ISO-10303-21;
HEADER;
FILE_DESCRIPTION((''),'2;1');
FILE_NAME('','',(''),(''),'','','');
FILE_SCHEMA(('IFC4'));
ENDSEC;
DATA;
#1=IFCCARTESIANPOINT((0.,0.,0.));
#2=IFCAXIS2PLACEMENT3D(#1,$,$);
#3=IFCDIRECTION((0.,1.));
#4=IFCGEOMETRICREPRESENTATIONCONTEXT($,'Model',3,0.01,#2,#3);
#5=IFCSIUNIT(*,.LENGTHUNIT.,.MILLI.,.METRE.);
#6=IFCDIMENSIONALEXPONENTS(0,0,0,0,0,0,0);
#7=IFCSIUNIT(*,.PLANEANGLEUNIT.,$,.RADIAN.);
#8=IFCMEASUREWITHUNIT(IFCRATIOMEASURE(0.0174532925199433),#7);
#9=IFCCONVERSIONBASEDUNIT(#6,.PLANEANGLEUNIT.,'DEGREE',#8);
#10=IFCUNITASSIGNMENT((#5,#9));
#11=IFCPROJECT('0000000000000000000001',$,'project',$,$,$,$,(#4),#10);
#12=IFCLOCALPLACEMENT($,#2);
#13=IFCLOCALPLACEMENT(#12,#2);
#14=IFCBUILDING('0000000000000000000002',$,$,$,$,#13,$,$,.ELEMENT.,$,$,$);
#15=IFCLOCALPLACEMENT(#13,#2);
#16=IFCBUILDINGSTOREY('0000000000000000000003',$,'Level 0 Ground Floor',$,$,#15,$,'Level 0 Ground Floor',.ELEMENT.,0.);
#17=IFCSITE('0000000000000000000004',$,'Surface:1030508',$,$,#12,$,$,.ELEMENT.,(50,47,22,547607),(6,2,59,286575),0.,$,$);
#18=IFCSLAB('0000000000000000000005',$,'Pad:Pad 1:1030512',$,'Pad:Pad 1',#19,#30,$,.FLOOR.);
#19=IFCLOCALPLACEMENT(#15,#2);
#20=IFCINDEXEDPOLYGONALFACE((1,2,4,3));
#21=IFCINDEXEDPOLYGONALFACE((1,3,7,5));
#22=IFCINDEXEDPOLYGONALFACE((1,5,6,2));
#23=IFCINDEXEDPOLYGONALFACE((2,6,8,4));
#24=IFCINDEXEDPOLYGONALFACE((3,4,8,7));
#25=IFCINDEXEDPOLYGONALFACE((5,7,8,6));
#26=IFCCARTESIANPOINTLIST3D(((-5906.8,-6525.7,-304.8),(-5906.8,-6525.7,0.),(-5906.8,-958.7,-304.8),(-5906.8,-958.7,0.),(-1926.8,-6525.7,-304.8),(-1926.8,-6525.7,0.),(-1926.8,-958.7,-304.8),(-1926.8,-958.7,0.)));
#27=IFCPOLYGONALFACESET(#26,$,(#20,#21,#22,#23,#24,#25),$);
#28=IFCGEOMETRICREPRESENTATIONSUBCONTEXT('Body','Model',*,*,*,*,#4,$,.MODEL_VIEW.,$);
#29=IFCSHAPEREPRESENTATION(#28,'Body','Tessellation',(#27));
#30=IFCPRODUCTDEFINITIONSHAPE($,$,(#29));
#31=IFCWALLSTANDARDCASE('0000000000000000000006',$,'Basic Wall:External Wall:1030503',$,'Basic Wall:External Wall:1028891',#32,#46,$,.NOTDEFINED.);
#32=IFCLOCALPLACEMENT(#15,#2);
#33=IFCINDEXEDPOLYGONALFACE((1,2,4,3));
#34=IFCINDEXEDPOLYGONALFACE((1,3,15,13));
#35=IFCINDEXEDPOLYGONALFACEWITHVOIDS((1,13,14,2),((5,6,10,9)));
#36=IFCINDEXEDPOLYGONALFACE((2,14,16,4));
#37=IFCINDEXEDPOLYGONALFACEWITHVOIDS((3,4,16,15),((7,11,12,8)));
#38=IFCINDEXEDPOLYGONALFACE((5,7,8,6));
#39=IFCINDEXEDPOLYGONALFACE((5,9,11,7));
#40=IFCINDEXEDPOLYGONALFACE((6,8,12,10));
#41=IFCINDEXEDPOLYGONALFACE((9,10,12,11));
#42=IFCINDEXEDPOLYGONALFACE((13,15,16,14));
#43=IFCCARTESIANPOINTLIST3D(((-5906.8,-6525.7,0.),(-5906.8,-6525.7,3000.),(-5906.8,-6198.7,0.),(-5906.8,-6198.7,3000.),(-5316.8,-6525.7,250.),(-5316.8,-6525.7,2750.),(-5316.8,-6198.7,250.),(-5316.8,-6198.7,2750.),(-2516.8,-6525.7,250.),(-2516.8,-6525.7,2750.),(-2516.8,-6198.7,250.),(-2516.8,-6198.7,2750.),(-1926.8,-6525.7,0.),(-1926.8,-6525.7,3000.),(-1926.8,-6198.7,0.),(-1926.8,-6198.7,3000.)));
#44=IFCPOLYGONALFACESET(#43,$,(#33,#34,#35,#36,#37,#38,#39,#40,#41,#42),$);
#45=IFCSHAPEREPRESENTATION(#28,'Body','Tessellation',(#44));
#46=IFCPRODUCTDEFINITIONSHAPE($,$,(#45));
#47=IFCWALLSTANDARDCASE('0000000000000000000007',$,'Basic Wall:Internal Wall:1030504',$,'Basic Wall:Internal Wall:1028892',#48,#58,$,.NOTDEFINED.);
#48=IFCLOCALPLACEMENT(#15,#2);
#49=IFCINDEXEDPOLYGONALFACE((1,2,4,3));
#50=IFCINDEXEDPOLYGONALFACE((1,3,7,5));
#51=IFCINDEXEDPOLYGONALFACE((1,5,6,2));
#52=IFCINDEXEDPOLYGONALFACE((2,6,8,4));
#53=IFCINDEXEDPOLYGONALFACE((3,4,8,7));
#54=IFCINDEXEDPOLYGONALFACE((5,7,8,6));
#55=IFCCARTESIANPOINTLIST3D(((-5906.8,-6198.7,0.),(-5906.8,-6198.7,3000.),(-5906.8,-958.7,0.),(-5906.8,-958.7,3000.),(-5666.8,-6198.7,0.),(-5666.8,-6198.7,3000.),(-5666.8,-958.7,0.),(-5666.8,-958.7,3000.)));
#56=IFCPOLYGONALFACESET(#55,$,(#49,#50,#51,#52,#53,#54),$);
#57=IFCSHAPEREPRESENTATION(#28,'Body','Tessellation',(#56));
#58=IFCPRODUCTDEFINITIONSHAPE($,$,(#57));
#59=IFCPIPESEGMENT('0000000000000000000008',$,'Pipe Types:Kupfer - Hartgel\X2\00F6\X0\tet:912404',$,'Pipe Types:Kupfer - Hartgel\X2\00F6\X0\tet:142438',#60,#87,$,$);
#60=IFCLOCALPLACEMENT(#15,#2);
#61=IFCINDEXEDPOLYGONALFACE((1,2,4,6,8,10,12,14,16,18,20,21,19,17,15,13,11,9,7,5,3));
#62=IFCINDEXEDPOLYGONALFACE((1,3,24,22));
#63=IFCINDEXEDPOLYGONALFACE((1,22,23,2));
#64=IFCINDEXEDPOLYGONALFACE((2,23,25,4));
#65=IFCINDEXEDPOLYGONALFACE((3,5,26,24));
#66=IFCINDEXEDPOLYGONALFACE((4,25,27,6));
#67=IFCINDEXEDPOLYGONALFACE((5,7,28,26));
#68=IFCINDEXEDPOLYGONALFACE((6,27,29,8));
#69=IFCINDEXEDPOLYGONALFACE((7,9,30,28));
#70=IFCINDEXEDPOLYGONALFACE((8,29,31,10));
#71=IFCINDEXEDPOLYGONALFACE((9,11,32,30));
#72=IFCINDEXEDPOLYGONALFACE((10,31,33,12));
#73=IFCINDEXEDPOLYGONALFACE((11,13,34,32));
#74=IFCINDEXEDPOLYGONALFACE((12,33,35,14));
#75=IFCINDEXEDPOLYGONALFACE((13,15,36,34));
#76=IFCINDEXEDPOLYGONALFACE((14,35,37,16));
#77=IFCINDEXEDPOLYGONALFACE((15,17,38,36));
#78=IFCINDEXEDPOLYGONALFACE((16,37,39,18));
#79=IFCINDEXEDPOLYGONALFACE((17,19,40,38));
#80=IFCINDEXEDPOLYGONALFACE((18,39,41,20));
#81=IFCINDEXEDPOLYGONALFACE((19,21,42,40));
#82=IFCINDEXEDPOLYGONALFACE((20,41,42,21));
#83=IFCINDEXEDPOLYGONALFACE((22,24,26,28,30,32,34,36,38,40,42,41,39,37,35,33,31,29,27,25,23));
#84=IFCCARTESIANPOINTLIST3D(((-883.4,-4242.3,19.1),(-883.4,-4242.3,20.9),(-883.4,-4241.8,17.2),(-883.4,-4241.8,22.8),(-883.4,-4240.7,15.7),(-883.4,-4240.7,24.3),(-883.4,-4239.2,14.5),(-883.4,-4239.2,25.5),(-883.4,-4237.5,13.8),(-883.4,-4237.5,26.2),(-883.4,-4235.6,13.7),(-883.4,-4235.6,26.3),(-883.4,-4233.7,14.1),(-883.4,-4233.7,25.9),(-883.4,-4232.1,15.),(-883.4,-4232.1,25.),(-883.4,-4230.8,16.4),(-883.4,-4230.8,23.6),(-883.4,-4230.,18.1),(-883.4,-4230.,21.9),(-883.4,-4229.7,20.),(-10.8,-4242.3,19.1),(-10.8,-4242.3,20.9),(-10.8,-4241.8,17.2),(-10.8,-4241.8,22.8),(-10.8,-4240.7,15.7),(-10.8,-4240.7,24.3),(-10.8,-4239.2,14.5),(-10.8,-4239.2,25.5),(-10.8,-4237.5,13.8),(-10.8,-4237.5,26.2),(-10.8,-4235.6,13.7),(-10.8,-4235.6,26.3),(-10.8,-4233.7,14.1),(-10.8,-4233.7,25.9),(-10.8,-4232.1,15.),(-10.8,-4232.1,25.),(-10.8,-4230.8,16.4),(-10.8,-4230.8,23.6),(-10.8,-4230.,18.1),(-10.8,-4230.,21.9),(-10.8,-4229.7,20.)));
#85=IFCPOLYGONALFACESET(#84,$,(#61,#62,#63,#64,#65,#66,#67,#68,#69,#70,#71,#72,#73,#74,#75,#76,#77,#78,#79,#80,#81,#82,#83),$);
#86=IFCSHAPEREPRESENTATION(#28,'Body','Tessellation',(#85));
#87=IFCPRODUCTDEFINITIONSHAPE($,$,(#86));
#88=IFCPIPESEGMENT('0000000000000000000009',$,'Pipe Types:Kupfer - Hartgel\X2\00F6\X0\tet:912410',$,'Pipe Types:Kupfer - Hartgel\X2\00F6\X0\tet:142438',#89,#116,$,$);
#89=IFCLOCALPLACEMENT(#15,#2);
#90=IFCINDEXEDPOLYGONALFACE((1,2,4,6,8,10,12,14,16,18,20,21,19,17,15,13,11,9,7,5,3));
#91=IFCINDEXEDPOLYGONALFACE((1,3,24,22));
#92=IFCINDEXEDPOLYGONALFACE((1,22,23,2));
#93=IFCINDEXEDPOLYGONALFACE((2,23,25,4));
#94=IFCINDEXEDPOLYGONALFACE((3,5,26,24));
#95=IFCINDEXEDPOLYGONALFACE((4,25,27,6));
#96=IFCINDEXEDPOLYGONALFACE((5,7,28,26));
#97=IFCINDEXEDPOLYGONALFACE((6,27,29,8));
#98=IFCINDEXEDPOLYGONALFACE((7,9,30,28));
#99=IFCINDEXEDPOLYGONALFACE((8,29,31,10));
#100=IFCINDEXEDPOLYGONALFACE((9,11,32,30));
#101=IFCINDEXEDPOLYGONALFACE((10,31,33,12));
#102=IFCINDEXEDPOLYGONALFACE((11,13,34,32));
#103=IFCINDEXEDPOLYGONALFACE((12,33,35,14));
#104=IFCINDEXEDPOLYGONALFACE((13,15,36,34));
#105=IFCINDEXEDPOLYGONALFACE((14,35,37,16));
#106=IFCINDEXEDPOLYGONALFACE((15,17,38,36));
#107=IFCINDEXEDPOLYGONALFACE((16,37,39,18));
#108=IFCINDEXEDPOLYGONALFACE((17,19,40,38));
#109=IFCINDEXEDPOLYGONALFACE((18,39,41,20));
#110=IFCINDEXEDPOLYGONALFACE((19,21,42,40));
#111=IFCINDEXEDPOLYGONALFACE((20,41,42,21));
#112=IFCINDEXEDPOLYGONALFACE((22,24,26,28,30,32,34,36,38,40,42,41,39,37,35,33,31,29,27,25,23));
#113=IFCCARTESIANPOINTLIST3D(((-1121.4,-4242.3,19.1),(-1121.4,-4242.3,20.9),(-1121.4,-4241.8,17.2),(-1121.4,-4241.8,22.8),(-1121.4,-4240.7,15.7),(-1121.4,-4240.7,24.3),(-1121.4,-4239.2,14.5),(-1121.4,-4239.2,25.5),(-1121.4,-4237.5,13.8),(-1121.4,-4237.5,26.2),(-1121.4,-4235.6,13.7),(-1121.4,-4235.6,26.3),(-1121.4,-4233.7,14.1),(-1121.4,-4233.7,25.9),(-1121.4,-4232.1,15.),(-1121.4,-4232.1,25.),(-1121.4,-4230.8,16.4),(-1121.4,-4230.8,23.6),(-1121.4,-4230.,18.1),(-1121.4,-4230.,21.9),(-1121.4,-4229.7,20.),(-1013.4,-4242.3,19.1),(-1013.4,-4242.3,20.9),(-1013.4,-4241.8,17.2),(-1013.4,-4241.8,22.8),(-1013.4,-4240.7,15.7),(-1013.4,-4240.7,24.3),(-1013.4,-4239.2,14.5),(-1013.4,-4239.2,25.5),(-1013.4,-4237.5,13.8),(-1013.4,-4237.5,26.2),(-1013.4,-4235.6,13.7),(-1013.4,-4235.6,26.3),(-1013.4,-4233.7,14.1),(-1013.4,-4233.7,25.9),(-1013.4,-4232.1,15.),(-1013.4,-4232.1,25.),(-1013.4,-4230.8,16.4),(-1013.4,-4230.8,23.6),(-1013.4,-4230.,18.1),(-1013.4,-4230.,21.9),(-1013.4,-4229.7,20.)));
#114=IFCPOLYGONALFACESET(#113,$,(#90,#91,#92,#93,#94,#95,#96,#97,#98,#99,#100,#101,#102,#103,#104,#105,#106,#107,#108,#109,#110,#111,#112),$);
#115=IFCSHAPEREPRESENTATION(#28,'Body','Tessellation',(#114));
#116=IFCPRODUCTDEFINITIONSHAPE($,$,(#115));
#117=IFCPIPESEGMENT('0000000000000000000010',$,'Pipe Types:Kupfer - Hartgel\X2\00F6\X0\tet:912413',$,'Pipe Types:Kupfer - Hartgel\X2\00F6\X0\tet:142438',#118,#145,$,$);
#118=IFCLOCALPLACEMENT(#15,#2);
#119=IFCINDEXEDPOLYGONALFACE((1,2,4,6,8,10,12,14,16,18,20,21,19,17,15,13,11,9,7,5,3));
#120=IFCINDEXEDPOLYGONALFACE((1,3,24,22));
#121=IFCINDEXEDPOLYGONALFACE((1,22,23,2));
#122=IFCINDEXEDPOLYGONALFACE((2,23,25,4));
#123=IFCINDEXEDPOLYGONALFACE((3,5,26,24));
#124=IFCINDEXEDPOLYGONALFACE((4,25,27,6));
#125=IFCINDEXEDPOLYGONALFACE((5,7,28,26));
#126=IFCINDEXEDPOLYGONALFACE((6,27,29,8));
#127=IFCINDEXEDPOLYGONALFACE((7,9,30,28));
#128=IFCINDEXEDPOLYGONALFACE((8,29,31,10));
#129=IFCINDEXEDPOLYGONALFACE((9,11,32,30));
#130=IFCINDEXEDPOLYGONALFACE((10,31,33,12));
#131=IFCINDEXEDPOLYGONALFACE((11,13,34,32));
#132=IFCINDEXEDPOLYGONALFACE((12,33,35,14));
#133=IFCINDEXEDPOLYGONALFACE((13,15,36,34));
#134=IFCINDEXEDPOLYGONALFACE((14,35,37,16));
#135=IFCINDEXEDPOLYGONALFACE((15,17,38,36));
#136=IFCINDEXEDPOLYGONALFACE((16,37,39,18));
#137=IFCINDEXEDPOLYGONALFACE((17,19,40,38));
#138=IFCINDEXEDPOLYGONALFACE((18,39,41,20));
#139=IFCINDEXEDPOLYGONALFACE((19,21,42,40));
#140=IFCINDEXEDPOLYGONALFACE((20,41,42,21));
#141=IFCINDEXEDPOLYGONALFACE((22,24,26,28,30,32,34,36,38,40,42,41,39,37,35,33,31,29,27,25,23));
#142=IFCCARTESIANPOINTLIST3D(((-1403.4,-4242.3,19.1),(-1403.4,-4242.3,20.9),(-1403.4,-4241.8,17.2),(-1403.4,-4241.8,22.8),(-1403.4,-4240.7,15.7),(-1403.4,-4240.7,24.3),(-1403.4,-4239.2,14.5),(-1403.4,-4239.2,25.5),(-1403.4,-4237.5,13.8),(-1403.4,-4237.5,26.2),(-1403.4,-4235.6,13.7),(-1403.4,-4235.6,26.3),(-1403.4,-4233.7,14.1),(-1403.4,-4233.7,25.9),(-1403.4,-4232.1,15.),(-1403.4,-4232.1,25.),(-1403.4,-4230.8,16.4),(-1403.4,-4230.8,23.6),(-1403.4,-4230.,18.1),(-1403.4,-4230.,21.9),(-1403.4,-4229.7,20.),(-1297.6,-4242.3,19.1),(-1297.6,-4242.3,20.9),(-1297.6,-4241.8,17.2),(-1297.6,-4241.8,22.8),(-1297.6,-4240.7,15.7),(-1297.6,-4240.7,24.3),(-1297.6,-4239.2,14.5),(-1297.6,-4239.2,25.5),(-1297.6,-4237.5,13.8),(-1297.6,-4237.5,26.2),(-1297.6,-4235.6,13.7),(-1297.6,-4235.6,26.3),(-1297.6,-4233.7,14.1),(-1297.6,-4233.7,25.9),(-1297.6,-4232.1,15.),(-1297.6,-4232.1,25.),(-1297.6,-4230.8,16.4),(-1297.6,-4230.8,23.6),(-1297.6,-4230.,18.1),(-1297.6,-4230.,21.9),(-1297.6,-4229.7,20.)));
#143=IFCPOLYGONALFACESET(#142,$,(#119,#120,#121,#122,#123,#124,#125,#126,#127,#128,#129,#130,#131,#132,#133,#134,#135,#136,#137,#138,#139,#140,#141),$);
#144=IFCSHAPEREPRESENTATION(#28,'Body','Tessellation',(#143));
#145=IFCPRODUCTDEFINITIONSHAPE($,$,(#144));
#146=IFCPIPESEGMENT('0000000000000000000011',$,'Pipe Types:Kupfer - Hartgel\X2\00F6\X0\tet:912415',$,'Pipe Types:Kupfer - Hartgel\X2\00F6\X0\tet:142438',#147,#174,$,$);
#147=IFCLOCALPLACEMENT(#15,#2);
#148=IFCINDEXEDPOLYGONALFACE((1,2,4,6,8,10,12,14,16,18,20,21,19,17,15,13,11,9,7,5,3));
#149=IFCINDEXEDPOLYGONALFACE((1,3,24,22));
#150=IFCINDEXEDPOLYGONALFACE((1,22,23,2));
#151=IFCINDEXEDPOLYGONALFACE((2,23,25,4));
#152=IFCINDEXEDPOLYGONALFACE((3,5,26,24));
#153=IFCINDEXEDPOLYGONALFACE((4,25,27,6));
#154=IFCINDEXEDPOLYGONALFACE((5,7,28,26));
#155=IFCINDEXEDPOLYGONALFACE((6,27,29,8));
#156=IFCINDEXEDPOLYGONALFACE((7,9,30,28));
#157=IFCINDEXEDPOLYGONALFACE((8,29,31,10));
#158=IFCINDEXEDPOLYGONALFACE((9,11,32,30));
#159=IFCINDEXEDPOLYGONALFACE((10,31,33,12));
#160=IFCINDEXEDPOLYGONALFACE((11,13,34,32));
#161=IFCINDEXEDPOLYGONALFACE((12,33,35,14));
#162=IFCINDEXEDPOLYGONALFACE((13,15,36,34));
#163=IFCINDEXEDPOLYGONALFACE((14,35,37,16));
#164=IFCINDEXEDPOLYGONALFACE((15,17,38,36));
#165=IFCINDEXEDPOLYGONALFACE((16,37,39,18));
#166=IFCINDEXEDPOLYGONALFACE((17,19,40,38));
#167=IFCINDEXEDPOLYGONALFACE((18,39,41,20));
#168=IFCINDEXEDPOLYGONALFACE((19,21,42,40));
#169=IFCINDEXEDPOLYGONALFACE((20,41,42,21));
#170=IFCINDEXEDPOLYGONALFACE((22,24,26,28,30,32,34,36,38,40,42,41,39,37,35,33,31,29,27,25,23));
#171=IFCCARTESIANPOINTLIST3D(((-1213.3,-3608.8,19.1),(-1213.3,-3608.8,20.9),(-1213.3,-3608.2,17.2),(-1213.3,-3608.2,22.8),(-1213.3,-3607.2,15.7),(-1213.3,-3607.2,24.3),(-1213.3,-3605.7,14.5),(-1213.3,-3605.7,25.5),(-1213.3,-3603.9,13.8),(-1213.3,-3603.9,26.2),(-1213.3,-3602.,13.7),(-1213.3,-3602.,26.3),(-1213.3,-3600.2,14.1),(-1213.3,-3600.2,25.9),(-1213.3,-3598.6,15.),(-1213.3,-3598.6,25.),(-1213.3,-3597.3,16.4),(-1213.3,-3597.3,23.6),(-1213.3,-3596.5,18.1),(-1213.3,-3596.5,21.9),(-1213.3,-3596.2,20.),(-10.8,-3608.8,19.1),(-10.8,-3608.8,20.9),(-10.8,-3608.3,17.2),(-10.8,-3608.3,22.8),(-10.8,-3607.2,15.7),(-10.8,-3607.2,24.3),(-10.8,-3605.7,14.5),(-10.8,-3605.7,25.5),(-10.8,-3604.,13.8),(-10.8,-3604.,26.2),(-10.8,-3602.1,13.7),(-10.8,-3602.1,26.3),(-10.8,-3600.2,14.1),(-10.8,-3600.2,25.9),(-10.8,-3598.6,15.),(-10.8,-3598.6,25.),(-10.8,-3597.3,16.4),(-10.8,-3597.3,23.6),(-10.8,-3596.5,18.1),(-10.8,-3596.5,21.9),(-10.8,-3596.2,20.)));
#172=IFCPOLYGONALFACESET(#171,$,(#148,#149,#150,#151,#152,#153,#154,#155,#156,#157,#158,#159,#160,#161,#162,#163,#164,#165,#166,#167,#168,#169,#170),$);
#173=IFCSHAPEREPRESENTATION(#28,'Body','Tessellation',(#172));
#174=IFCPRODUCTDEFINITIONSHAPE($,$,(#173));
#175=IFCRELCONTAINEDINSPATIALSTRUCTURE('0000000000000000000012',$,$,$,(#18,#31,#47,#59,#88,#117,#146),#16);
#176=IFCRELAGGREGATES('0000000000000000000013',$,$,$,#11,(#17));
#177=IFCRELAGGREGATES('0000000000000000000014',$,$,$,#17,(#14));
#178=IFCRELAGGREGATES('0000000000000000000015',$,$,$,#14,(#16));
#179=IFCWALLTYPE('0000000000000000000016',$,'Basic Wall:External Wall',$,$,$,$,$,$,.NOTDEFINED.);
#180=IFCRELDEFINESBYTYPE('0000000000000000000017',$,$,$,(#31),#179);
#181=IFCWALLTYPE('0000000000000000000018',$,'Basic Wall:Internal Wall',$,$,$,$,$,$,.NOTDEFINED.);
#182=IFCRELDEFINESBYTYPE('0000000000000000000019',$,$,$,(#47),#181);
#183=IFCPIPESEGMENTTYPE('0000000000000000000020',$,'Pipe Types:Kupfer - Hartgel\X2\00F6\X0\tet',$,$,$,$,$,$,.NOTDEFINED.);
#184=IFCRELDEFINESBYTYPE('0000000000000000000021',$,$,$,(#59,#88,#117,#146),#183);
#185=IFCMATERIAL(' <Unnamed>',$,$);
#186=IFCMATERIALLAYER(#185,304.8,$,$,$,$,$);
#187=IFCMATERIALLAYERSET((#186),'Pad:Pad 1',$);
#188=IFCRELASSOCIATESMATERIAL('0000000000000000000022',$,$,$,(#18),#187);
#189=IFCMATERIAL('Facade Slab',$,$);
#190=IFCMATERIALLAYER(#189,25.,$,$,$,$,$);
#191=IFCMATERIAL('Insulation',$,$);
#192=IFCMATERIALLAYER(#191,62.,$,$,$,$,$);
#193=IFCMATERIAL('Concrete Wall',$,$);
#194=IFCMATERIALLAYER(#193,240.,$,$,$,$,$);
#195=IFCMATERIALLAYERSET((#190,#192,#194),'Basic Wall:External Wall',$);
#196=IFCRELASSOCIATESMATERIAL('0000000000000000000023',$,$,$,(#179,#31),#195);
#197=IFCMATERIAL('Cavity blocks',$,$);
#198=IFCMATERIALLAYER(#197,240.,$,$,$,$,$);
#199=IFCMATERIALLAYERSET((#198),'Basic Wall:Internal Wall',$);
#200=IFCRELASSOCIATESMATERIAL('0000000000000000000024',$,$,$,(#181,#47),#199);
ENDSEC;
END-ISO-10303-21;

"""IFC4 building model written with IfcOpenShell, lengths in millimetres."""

from ifc_helpers import new_model, entity, si_unit, converted_unit, direction, frame, frame_2d, origin, place, context, subcontext, project, spatial, polyline, rectangle, circle, extrude, clip, bounded_halfspace, material, layer, layer_set, layer_usage, type_object, element, save


model = new_model("IFC4")

# Units and contexts
model_context = context("Model", 3, precision=0.01, world=origin(), true_north=direction((0.0, 1.0)))
body_context = subcontext(model_context, "Body", "Model", "MODEL_VIEW")
ifc_project = project(units=[si_unit("LENGTHUNIT", "METRE", prefix="MILLI"), converted_unit("PLANEANGLEUNIT", "DEGREE", entity("IfcRatioMeasure", 0.0174532925199433), si_unit("PLANEANGLEUNIT", "RADIAN"), dimensions=[0, 0, 0, 0, 0, 0, 0])], contexts=[model_context])

# Site, building, storey
site_placement = place(None, origin())
site = spatial("IfcSite", under=ifc_project, at=site_placement, Name="Surface:1030508", CompositionType="ELEMENT", RefLatitude=(50, 47, 22, 547607), RefLongitude=(6, 2, 59, 286575), RefElevation=0.0)
building_placement = place(site_placement, origin())
building = spatial("IfcBuilding", under=site, at=building_placement, CompositionType="ELEMENT")
storey_placement = place(building_placement, origin())
storey = spatial("IfcBuildingStorey", under=building, at=storey_placement, Name="Level 0 Ground Floor", LongName="Level 0 Ground Floor", CompositionType="ELEMENT", Elevation=0.0)

# Slab
ifc_material_1 = material(Name=" <Unnamed>")
ifc_layer_1 = layer(ifc_material_1, 304.8)
ifc_layer_set_1 = layer_set([ifc_layer_1], Name="Pad:Pad 1")
ifc_layer_usage_1 = layer_usage(ifc_layer_set_1, "AXIS3", "NEGATIVE", 0.0)
slab_placement = place(storey_placement, frame((-5906.8, -6525.7, -304.8)))
element("IfcSlab", 1, at=slab_placement, inside=storey, material=ifc_layer_usage_1, Name="Pad:Pad 1:1030512", ObjectType="Pad:Pad 1", PredefinedType="FLOOR", context=body_context, shape_type="SweptSolid", body=[
    extrude(rectangle(XDim=5567.0, YDim=3980.0, at=frame_2d((0.0, 0.0), x_axis=(0.0, -1.0))), frame((1990.0, 2783.5, 304.8), z_axis=(0.0, 0.0, -1.0), x_axis=(-1.0, 0.0, 0.0)), (0.0, 0.0, 1.0), 304.8),
])

# Wall, opening
ifc_material_2 = material(Name="Facade Slab")
ifc_layer_2 = layer(ifc_material_2, 25.0)
ifc_material_3 = material(Name="Insulation")
ifc_layer_3 = layer(ifc_material_3, 62.0)
ifc_material_4 = material(Name="Concrete Wall")
ifc_layer_4 = layer(ifc_material_4, 240.0)
ifc_layer_set_2 = layer_set([ifc_layer_2, ifc_layer_3, ifc_layer_4], Name="Basic Wall:External Wall")
ifc_layer_usage_2 = layer_usage(ifc_layer_set_2, "AXIS2", "POSITIVE", -163.5)
wall_type_1 = type_object("IfcWallType", Name="Basic Wall:External Wall", PredefinedType="NOTDEFINED", material=ifc_layer_set_2)
wall_1_placement = place(storey_placement, frame((-5906.8, -6362.2, 0.0)))
wall_1 = element("IfcWallStandardCase", 2, at=wall_1_placement, inside=storey, type_object=wall_type_1, material=ifc_layer_usage_2, Name="Basic Wall:External Wall:1030503", ObjectType="Basic Wall:External Wall:1028891", PredefinedType="NOTDEFINED", context=body_context, shape_type="Clipping", body=[
    clip(extrude(rectangle(XDim=3980.0, YDim=327.0, at=frame_2d((1990.0, 0.0), x_axis=(-1.0, 0.0))), origin(), (0.0, 0.0, 1.0), 3000.0), bounded_halfspace(frame((0.0, -163.5, 3000.0), z_axis=(0.0, 0.0, -1.0), x_axis=(0.0, -1.0, 0.0)), True, frame((0.0, -163.5, 3000.0)), polyline([(0.0, 0.0), (3980.0, 0.0), (3980.0, 327.0), (3740.0, 327.0), (240.0, 327.0), (0.0, 327.0), (0.0, 0.0)]))),
])
opening_placement = place(wall_1_placement, frame((590.0, -163.5, 250.0)))
element("IfcOpeningElement", 3, at=opening_placement, cuts=wall_1, ObjectType="Opening", PredefinedType="OPENING", context=body_context, shape_type="SweptSolid", body=[
    extrude(rectangle(XDim=2500.0, YDim=2800.0, at=frame_2d((1250.0, 1400.0), x_axis=(1.0, 0.0))), frame((0.0, 0.0, 0.0), z_axis=(0.0, 1.0, 0.0), x_axis=(0.0, 0.0, 1.0)), (0.0, 0.0, 1.0), 327.0),
])

# Wall
ifc_material_5 = material(Name="Cavity blocks")
ifc_layer_5 = layer(ifc_material_5, 240.0)
ifc_layer_set_3 = layer_set([ifc_layer_5], Name="Basic Wall:Internal Wall")
ifc_layer_usage_3 = layer_usage(ifc_layer_set_3, "AXIS2", "NEGATIVE", 120.0)
wall_type_2 = type_object("IfcWallType", Name="Basic Wall:Internal Wall", PredefinedType="NOTDEFINED", material=ifc_layer_set_3)
wall_2_placement = place(storey_placement, frame((-5786.8, -6198.7, 0.0), z_axis=(0.0, 0.0, 1.0), x_axis=(0.0, 1.0, 0.0)))
element("IfcWallStandardCase", 4, at=wall_2_placement, inside=storey, type_object=wall_type_2, material=ifc_layer_usage_3, Name="Basic Wall:Internal Wall:1030504", ObjectType="Basic Wall:Internal Wall:1028892", PredefinedType="NOTDEFINED", context=body_context, shape_type="Clipping", body=[
    clip(extrude(rectangle(XDim=5240.0, YDim=240.0, at=frame_2d((2620.0, 0.0), x_axis=(-1.0, 0.0))), origin(), (0.0, 0.0, 1.0), 3000.0), bounded_halfspace(frame((0.0, -120.0, 3000.0), z_axis=(0.0, 0.0, -1.0), x_axis=(-1.0, 0.0, 0.0)), True, frame((0.0, -120.0, 3000.0)), polyline([(0.0, 0.0), (5000.0, 0.0), (5240.0, 0.0), (5240.0, 240.0), (0.0, 240.0), (0.0, 0.0)]))),
])

# Pipe segments
pipe_segment_type = type_object("IfcPipeSegmentType", Name="Pipe Types:Kupfer - Hartgelötet", PredefinedType="NOTDEFINED")
pipe_segment_1_placement = place(storey_placement, frame((-883.4, -4244.0, 12.1)))
element("IfcPipeSegment", 5, at=pipe_segment_1_placement, inside=storey, type_object=pipe_segment_type, Name="Pipe Types:Kupfer - Hartgelötet:912404", ObjectType="Pipe Types:Kupfer - Hartgelötet:142438", context=body_context, shape_type="SweptSolid", body=[
    extrude(circle(Radius=6.3, at=frame_2d((0.0, 0.0), x_axis=(1.0, 0.0))), frame((0.0, 7.9, 7.9), z_axis=(1.0, 0.0, 0.0), x_axis=(0.0, 1.0, 0.0)), (0.0, 0.0, 1.0), 872.6),
])
pipe_segment_2_placement = place(storey_placement, frame((-1121.4, -4244.0, 12.1)))
element("IfcPipeSegment", 6, at=pipe_segment_2_placement, inside=storey, type_object=pipe_segment_type, Name="Pipe Types:Kupfer - Hartgelötet:912410", ObjectType="Pipe Types:Kupfer - Hartgelötet:142438", context=body_context, shape_type="SweptSolid", body=[
    extrude(circle(Radius=6.3, at=frame_2d((0.0, 0.0), x_axis=(1.0, 0.0))), frame((0.0, 7.9, 7.9), z_axis=(1.0, 0.0, 0.0), x_axis=(0.0, 1.0, 0.0)), (0.0, 0.0, 1.0), 108.0),
])
pipe_segment_3_placement = place(storey_placement, frame((-1403.4, -4244.0, 12.1)))
element("IfcPipeSegment", 7, at=pipe_segment_3_placement, inside=storey, type_object=pipe_segment_type, Name="Pipe Types:Kupfer - Hartgelötet:912413", ObjectType="Pipe Types:Kupfer - Hartgelötet:142438", context=body_context, shape_type="SweptSolid", body=[
    extrude(circle(Radius=6.3, at=frame_2d((0.0, 0.0), x_axis=(1.0, 0.0))), frame((0.0, 7.9, 7.9), z_axis=(1.0, 0.0, 0.0), x_axis=(0.0, 1.0, 0.0)), (0.0, 0.0, 1.0), 105.8),
])
pipe_segment_4_placement = place(storey_placement, frame((-1213.3, -3610.5, 12.1)))
element("IfcPipeSegment", 8, at=pipe_segment_4_placement, inside=storey, type_object=pipe_segment_type, Name="Pipe Types:Kupfer - Hartgelötet:912415", ObjectType="Pipe Types:Kupfer - Hartgelötet:142438", context=body_context, shape_type="SweptSolid", body=[
    extrude(circle(Radius=6.3, at=frame_2d((0.0, 0.0), x_axis=(1.0, 0.0))), frame((0.0, 8.0, 7.9), z_axis=(1.0, -0.000035, 0.0), x_axis=(0.000035, 1.0, 0.0)), (0.0, 0.0, 1.0), 1202.5),
])

save(model, "model.ifc")
